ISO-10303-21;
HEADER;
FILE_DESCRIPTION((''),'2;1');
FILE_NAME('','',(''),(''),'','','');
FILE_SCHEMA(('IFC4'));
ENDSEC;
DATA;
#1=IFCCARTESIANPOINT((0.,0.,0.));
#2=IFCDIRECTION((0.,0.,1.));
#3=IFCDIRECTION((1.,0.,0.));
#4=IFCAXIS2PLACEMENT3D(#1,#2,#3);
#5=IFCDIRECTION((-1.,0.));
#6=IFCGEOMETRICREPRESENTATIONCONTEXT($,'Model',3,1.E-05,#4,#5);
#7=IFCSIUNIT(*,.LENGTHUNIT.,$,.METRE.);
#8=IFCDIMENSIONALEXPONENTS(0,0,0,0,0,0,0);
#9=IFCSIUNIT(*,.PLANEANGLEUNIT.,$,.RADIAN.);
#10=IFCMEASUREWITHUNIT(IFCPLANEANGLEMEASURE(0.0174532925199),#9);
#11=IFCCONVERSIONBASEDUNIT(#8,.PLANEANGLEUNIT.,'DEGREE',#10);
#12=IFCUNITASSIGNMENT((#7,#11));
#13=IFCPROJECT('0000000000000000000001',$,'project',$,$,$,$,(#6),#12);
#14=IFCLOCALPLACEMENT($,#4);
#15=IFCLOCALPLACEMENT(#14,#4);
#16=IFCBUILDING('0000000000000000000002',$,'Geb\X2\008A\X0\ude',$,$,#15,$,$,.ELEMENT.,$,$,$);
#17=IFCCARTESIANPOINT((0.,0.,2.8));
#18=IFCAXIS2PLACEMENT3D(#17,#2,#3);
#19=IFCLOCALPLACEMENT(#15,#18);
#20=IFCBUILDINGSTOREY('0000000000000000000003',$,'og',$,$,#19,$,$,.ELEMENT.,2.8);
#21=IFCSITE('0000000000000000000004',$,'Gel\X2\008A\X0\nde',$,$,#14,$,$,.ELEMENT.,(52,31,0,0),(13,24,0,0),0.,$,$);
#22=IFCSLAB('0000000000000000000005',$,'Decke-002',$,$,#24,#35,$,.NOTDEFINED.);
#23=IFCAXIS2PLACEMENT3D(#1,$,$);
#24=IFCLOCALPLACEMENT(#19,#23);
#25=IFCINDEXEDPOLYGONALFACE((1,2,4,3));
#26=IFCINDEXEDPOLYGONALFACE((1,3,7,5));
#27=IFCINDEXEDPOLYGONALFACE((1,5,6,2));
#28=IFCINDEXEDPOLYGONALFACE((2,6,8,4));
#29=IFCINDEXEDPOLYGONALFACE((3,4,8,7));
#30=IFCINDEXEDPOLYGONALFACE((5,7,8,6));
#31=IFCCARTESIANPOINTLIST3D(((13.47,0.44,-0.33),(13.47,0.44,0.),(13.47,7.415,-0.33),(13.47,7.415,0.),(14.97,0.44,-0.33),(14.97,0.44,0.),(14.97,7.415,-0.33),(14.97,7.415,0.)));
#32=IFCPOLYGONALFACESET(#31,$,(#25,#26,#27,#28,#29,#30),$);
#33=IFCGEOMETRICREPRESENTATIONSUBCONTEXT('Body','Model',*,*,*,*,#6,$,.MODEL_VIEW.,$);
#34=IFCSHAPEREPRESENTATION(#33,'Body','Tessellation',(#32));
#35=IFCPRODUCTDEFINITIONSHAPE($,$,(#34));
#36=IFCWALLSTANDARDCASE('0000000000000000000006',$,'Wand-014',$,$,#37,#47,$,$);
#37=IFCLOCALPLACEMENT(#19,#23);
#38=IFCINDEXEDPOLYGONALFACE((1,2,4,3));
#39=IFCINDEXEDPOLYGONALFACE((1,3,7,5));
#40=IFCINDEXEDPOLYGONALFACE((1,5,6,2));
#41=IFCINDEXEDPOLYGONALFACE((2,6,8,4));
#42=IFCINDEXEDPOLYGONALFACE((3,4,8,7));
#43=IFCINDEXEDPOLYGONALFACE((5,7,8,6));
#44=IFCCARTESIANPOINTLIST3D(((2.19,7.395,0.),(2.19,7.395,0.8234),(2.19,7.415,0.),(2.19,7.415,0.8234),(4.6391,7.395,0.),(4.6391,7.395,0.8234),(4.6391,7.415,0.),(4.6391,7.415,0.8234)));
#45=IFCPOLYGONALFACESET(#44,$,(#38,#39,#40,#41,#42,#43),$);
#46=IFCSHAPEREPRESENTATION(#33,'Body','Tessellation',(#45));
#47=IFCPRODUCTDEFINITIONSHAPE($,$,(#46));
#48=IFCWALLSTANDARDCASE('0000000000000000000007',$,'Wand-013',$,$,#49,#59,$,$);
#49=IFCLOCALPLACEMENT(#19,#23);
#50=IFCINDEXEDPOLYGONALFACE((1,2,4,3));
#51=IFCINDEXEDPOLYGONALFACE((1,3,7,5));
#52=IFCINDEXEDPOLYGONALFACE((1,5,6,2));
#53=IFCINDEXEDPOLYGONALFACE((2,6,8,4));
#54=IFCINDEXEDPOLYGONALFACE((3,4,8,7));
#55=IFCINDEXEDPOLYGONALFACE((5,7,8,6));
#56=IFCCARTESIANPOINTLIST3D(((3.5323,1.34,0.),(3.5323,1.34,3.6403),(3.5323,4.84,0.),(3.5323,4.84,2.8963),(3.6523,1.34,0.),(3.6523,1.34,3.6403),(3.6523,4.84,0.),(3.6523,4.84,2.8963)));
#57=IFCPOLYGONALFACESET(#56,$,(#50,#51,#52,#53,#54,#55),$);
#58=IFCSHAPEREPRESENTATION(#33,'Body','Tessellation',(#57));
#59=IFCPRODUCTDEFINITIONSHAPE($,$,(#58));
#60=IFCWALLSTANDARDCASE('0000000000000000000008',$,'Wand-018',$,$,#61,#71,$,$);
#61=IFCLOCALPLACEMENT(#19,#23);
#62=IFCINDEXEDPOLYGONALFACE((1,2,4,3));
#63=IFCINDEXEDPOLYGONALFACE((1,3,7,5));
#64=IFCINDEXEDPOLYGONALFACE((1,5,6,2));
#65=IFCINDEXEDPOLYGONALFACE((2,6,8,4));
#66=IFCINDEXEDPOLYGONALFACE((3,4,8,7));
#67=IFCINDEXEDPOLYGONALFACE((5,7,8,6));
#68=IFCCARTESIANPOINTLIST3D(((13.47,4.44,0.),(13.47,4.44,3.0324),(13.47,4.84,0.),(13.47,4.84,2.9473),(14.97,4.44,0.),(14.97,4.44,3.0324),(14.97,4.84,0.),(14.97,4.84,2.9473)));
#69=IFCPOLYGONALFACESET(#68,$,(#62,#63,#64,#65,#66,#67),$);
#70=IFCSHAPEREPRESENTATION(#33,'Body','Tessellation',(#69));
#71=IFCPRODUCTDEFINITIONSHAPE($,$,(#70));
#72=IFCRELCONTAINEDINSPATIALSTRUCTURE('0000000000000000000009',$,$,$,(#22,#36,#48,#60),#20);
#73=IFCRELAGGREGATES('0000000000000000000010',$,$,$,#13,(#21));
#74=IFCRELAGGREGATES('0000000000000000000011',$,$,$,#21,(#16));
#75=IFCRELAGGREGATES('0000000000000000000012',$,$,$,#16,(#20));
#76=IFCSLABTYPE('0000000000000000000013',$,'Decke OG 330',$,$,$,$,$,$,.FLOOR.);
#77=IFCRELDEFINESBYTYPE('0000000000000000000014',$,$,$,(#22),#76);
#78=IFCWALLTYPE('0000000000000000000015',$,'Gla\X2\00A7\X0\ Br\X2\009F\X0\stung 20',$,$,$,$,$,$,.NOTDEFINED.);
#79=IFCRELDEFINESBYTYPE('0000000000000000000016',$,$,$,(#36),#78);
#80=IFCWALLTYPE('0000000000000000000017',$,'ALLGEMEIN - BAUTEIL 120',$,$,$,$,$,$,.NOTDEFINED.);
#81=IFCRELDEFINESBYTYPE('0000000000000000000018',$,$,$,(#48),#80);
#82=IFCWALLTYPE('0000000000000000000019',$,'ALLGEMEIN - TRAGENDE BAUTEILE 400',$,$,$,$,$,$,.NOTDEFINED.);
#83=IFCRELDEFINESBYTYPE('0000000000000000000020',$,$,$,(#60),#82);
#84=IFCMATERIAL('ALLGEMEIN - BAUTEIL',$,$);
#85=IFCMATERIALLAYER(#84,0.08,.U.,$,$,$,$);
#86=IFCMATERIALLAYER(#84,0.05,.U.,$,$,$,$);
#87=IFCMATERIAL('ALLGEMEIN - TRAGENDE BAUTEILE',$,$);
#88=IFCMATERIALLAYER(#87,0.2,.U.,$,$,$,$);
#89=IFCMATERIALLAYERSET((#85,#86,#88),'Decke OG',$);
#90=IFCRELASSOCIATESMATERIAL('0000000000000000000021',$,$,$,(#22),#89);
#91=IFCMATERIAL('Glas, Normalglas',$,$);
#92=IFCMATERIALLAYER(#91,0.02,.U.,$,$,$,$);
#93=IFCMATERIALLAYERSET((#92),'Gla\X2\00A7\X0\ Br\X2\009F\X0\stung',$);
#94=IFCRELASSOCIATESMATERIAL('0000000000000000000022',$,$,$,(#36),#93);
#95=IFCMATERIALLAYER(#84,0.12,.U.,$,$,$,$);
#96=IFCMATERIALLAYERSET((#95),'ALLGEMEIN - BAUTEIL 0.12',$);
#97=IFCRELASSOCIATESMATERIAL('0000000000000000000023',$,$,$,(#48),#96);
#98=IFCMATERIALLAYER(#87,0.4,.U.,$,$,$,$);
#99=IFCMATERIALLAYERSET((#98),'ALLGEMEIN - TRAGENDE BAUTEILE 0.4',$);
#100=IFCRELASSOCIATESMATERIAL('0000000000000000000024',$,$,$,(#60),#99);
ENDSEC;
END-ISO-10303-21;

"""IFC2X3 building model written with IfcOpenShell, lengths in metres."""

from ifc_helpers import new_model, entity, si_unit, converted_unit, direction, frame, origin_with_axes, place, context, subcontext, project, spatial, polyline, outline, extrude, clip, halfspace, material, layer, layer_set, layer_usage, type_object, element, save


model = new_model("IFC2X3")

# Units and contexts
model_context = context("Model", 3, precision=1e-05, world=origin_with_axes(), true_north=direction((-1.0, 0.0)))
body_context = subcontext(model_context, "Body", "Model", "MODEL_VIEW")
ifc_project = project(units=[si_unit("LENGTHUNIT", "METRE"), converted_unit("PLANEANGLEUNIT", "DEGREE", entity("IfcPlaneAngleMeasure", 0.0174532925199), si_unit("PLANEANGLEUNIT", "RADIAN"), dimensions=[0, 0, 0, 0, 0, 0, 0])], contexts=[model_context])

# Site, building, storey
site_placement = place(None, origin_with_axes())
site = spatial("IfcSite", under=ifc_project, at=site_placement, Name="Gel\u008ande", CompositionType="ELEMENT", RefLatitude=(52, 31, 0, 0), RefLongitude=(13, 24, 0, 0), RefElevation=0.0)
building_placement = place(site_placement, origin_with_axes())
building = spatial("IfcBuilding", under=site, at=building_placement, Name="Geb\u008aude", CompositionType="ELEMENT")
storey_placement = place(building_placement, frame((0.0, 0.0, 2.8), z_axis=(0.0, 0.0, 1.0), x_axis=(1.0, 0.0, 0.0)))
storey = spatial("IfcBuildingStorey", under=building, at=storey_placement, Name="og", CompositionType="ELEMENT", Elevation=2.8)

# Slab
ifc_material_1 = material(Name="ALLGEMEIN - BAUTEIL")
ifc_layer_1 = layer(ifc_material_1, 0.08, ventilated="UNKNOWN")
ifc_layer_2 = layer(ifc_material_1, 0.05, ventilated="UNKNOWN")
ifc_material_2 = material(Name="ALLGEMEIN - TRAGENDE BAUTEILE")
ifc_layer_3 = layer(ifc_material_2, 0.2, ventilated="UNKNOWN")
ifc_layer_set_1 = layer_set([ifc_layer_1, ifc_layer_2, ifc_layer_3], Name="Decke OG")
ifc_layer_usage_1 = layer_usage(ifc_layer_set_1, "AXIS3", "NEGATIVE", 0.33)
slab_type = type_object("IfcSlabType", Name="Decke OG 330", PredefinedType="FLOOR")
slab_1_placement = place(storey_placement, frame((14.97, 7.415, 0.0), z_axis=(0.0, 0.0, 1.0), x_axis=(1.0, 0.0, 0.0)))
element("IfcSlab", 1, at=slab_1_placement, inside=storey, type_object=slab_type, material=ifc_layer_usage_1, Name="Decke-002", PredefinedType="NOTDEFINED", context=body_context, shape_type="SweptSolid", body=[
    extrude(outline(polyline([(0.0, 0.0), (-1.5, 0.0), (-1.5, -6.975), (0.0, -6.975), (0.0, 0.0)])), frame((0.0, 0.0, -0.33), z_axis=(0.0, 0.0, 1.0), x_axis=(1.0, 0.0, 0.0)), (0.0, 0.0, 1.0), 0.33),
])

# Wall
ifc_material_3 = material(Name="Glas, Normalglas")
ifc_layer_4 = layer(ifc_material_3, 0.02, ventilated="UNKNOWN")
ifc_layer_set_2 = layer_set([ifc_layer_4], Name="Gla§ Br\u009fstung")
ifc_layer_usage_2 = layer_usage(ifc_layer_set_2, "AXIS2", "NEGATIVE", 0.0)
wall_type_1 = type_object("IfcWallType", Name="Gla§ Br\u009fstung 20", PredefinedType="NOTDEFINED")
wall_1_placement = place(storey_placement, frame((2.19, 7.415, 0.0), z_axis=(0.0, 0.0, 1.0), x_axis=(1.0, 0.0, 0.0)))
element("IfcWallStandardCase", 2, at=wall_1_placement, inside=storey, type_object=wall_type_1, material=ifc_layer_usage_2, Name="Wand-014", context=body_context, shape_type="SweptSolid", body=[
    extrude(outline(polyline([(0.0, -0.02), (2.4491, -0.02), (2.4491, 0.0), (0.0, 0.0), (0.0, -0.02)])), origin_with_axes(), (0.0, 0.0, 1.0), 0.8234),
])

# Walls
ifc_layer_5 = layer(ifc_material_1, 0.12, ventilated="UNKNOWN")
ifc_layer_set_3 = layer_set([ifc_layer_5], Name="ALLGEMEIN - BAUTEIL 0.12")
ifc_layer_usage_3 = layer_usage(ifc_layer_set_3, "AXIS2", "NEGATIVE", 0.0)
wall_type_2 = type_object("IfcWallType", Name="ALLGEMEIN - BAUTEIL 120", PredefinedType="NOTDEFINED")
wall_2_placement = place(storey_placement, frame((3.6523, 4.84, 0.0), z_axis=(0.0, 0.0, 1.0), x_axis=(0.0, -1.0, 0.0)))
element("IfcWallStandardCase", 3, at=wall_2_placement, inside=storey, type_object=wall_type_2, material=ifc_layer_usage_3, Name="Wand-013", context=body_context, shape_type="Clipping", body=[
    clip(extrude(outline(polyline([(0.0, -0.12), (3.5, -0.12), (3.5, 0.0), (0.0, 0.0), (0.0, -0.12)])), origin_with_axes(), (0.0, 0.0, 1.0), 6.0), halfspace(frame((-0.589, 0.0, 2.7711), z_axis=(0.207912, 0.0, -0.978148), x_axis=(0.978148, 0.0, 0.207912)), True)),
])
ifc_layer_6 = layer(ifc_material_2, 0.4, ventilated="UNKNOWN")
ifc_layer_set_4 = layer_set([ifc_layer_6], Name="ALLGEMEIN - TRAGENDE BAUTEILE 0.4")
ifc_layer_usage_4 = layer_usage(ifc_layer_set_4, "AXIS2", "POSITIVE", -0.4)
wall_type_3 = type_object("IfcWallType", Name="ALLGEMEIN - TRAGENDE BAUTEILE 400", PredefinedType="NOTDEFINED")
wall_3_placement = place(storey_placement, frame((13.47, 4.84, 0.0), z_axis=(0.0, 0.0, 1.0), x_axis=(1.0, 0.0, 0.0)))
element("IfcWallStandardCase", 4, at=wall_3_placement, inside=storey, type_object=wall_type_3, material=ifc_layer_usage_4, Name="Wand-018", context=body_context, shape_type="Clipping", body=[
    clip(extrude(outline(polyline([(0.0, -0.4), (1.5, -0.4), (1.5, 0.0), (0.0, 0.0), (0.0, -0.4)])), origin_with_axes(), (0.0, 0.0, 1.0), 4.3), halfspace(frame((0.0, 0.5994, 2.8199), z_axis=(0.0, -0.207912, -0.978148), x_axis=(0.0, -0.978148, 0.207912)), True)),
])

save(model, "model.ifc")
